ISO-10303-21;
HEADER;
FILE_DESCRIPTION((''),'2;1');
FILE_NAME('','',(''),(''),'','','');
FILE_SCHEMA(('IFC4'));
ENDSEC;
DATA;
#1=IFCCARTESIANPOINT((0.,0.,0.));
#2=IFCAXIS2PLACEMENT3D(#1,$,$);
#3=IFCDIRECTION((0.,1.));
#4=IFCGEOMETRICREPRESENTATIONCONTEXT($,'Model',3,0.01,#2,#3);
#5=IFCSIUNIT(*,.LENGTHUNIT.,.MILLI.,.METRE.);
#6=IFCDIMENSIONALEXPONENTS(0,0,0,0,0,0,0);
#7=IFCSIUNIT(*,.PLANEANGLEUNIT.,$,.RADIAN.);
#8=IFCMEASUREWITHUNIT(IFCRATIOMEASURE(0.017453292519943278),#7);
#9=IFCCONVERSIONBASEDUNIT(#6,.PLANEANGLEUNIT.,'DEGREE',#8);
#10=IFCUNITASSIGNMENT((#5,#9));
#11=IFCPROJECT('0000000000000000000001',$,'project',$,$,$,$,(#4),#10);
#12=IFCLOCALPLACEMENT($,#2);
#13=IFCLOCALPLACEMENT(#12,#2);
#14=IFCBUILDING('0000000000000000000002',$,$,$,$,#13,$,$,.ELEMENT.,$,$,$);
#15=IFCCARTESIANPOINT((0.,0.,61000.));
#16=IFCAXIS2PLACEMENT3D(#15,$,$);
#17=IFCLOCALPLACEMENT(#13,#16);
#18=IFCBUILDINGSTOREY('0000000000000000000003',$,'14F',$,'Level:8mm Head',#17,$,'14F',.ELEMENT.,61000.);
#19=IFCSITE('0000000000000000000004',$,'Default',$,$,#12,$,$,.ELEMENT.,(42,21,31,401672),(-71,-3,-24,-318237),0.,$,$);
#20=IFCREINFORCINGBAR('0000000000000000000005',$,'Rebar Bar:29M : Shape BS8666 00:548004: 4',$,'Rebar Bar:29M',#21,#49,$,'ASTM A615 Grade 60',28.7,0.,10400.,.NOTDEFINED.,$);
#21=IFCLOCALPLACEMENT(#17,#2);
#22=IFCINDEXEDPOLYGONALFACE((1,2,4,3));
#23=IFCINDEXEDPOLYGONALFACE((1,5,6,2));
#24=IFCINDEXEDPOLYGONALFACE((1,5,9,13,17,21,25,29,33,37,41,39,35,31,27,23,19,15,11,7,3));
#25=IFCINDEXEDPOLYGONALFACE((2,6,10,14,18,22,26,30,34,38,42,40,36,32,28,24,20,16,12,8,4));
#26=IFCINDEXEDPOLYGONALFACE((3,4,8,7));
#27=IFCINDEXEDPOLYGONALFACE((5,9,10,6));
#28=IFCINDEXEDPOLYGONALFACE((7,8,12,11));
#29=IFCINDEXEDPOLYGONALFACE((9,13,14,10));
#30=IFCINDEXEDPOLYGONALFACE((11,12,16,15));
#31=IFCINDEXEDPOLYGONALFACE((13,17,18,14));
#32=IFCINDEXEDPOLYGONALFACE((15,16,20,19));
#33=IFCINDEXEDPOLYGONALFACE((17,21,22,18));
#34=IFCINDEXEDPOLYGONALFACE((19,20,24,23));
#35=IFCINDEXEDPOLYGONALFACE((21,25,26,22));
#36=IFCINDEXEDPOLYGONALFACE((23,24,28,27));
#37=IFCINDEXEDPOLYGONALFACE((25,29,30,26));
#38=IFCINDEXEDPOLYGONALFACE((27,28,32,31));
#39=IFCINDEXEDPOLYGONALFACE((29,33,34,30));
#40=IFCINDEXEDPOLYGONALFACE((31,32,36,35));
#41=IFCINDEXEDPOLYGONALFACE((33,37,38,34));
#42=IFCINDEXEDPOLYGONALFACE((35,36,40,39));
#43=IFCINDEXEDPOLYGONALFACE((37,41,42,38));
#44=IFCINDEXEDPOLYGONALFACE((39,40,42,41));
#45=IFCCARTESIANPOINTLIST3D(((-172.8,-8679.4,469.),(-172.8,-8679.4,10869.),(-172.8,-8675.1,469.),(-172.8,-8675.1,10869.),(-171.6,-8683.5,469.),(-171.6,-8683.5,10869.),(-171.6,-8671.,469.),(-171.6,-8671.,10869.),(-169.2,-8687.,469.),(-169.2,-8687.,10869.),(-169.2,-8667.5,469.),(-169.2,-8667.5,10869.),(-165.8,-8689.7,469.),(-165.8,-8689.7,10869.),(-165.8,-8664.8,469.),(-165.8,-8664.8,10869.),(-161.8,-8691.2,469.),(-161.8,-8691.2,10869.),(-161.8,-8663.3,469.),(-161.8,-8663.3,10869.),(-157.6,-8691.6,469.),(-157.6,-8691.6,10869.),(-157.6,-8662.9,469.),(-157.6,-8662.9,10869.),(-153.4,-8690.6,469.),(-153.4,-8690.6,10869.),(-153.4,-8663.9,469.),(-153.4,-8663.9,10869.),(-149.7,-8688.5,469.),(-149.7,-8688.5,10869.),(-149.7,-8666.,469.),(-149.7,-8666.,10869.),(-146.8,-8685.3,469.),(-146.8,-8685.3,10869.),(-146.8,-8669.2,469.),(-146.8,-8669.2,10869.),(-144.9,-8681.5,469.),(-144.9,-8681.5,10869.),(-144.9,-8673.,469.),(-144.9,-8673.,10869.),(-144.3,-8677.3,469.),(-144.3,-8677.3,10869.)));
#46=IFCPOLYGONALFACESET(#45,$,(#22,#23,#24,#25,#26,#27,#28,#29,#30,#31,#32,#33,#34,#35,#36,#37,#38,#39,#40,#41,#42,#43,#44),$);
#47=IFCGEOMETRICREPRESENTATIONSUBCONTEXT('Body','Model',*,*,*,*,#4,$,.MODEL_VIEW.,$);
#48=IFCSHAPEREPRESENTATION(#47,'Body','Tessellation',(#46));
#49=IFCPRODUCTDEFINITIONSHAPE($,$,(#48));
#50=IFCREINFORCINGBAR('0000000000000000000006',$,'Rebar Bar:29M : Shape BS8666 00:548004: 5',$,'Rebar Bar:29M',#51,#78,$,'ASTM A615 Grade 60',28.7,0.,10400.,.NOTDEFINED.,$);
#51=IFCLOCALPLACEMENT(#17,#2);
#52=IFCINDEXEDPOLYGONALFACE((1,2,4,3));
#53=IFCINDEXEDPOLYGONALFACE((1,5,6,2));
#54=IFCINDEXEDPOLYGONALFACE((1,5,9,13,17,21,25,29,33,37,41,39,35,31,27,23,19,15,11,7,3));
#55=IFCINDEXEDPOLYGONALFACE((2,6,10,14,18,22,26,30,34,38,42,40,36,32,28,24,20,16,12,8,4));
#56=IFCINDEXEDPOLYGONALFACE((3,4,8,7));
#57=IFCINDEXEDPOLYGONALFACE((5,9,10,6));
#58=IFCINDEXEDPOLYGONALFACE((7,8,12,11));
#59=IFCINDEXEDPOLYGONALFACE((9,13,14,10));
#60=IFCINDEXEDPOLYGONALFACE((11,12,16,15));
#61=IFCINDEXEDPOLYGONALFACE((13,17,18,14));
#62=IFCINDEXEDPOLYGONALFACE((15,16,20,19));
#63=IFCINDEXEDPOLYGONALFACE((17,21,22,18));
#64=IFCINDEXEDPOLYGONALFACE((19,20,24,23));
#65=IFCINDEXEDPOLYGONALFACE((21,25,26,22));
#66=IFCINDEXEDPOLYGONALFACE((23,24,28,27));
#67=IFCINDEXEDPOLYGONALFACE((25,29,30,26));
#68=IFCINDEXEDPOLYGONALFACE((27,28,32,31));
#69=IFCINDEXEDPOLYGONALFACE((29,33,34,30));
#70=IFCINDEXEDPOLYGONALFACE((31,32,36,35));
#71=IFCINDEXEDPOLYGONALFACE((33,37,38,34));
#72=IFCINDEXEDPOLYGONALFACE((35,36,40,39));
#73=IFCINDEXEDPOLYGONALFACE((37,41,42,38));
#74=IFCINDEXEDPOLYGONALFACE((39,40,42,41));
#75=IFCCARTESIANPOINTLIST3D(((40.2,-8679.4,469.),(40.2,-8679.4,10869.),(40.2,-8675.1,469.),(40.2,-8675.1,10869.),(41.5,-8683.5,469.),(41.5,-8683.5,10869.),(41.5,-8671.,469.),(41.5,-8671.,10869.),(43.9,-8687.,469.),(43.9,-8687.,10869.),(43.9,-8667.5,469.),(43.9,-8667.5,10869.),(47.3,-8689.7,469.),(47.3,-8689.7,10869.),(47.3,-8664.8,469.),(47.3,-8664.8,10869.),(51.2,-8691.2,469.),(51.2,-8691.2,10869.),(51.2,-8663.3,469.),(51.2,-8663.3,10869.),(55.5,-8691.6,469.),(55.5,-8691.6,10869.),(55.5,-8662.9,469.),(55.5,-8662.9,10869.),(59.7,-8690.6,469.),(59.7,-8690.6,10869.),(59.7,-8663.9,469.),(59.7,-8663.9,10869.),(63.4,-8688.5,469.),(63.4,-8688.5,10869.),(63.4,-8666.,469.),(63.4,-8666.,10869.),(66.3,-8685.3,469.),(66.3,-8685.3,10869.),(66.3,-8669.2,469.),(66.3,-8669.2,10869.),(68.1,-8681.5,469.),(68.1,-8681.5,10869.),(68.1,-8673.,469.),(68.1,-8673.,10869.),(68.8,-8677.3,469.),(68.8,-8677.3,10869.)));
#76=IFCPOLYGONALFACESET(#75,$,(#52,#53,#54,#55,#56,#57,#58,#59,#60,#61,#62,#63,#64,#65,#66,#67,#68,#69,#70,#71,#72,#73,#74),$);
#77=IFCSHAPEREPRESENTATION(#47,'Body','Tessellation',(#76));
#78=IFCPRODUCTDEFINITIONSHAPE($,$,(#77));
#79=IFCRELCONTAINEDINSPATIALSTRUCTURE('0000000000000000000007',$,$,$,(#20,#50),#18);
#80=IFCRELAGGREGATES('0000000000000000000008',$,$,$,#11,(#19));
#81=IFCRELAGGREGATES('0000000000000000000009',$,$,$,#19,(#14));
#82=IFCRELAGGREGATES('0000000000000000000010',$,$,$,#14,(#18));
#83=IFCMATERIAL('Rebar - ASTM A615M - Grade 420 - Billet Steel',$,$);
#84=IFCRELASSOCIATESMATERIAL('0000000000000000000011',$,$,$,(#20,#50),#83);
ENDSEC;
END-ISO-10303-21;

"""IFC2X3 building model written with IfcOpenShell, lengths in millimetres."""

from ifc_helpers import new_model, entity, si_unit, converted_unit, direction, frame, origin, place, context, subcontext, project, spatial, material, element, save


model = new_model("IFC2X3")

# Units and contexts
model_context = context("Model", 3, precision=0.01, world=origin(), true_north=direction((0.0, 1.0)))
body_context = subcontext(model_context, "Body", "Model", "MODEL_VIEW")
ifc_project = project(units=[si_unit("LENGTHUNIT", "METRE", prefix="MILLI"), converted_unit("PLANEANGLEUNIT", "DEGREE", entity("IfcRatioMeasure", 0.017453292519943278), si_unit("PLANEANGLEUNIT", "RADIAN"), dimensions=[0, 0, 0, 0, 0, 0, 0])], contexts=[model_context])

# Site, building, storey
site_placement = place(None, origin())
site = spatial("IfcSite", under=ifc_project, at=site_placement, Name="Default", CompositionType="ELEMENT", RefLatitude=(42, 21, 31, 401672), RefLongitude=(-71, -3, -24, -318237), RefElevation=0.0)
building_placement = place(site_placement, origin())
building = spatial("IfcBuilding", under=site, at=building_placement, CompositionType="ELEMENT")
storey_placement = place(building_placement, frame((0.0, 0.0, 61000.0)))
storey = spatial("IfcBuildingStorey", under=building, at=storey_placement, Name="14F", ObjectType="Level:8mm Head", LongName="14F", CompositionType="ELEMENT", Elevation=61000.0)

# Reinforcing bars
ifc_material_1 = material(Name="Rebar - ASTM A615M - Grade 420 - Billet Steel")
reinforcing_bar_1_placement = place(storey_placement, origin())
element("IfcReinforcingBar", 1, at=reinforcing_bar_1_placement, inside=storey, material=ifc_material_1, Name="Rebar Bar:29M : Shape BS8666 00:548004: 4", SteelGrade="ASTM A615 Grade 60", ObjectType="Rebar Bar:29M", BarLength=10400.0, BarRole="NOTDEFINED", CrossSectionArea=0.0, NominalDiameter=28.7, context=body_context, shape_type="AdvancedSweptSolid", body=[
    entity("IfcSweptDiskSolid", entity("IfcCompositeCurve", [entity("IfcCompositeCurveSegment", "CONTINUOUS", True, entity("IfcPolyline", [entity("IfcCartesianPoint", [-158.6, -8677.3, 469.0]), entity("IfcCartesianPoint", [-158.6, -8677.3, 10869.0])]))], False), 14.3, None, 0.0, 1.0),
])
reinforcing_bar_2_placement = place(storey_placement, origin())
element("IfcReinforcingBar", 2, at=reinforcing_bar_2_placement, inside=storey, material=ifc_material_1, Name="Rebar Bar:29M : Shape BS8666 00:548004: 5", SteelGrade="ASTM A615 Grade 60", ObjectType="Rebar Bar:29M", BarLength=10400.0, BarRole="NOTDEFINED", CrossSectionArea=0.0, NominalDiameter=28.7, context=body_context, shape_type="AdvancedSweptSolid", body=[
    entity("IfcSweptDiskSolid", entity("IfcCompositeCurve", [entity("IfcCompositeCurveSegment", "CONTINUOUS", True, entity("IfcPolyline", [entity("IfcCartesianPoint", [54.4, -8677.3, 469.0]), entity("IfcCartesianPoint", [54.4, -8677.3, 10869.0])]))], False), 14.3, None, 0.0, 1.0),
])

save(model, "model.ifc")
